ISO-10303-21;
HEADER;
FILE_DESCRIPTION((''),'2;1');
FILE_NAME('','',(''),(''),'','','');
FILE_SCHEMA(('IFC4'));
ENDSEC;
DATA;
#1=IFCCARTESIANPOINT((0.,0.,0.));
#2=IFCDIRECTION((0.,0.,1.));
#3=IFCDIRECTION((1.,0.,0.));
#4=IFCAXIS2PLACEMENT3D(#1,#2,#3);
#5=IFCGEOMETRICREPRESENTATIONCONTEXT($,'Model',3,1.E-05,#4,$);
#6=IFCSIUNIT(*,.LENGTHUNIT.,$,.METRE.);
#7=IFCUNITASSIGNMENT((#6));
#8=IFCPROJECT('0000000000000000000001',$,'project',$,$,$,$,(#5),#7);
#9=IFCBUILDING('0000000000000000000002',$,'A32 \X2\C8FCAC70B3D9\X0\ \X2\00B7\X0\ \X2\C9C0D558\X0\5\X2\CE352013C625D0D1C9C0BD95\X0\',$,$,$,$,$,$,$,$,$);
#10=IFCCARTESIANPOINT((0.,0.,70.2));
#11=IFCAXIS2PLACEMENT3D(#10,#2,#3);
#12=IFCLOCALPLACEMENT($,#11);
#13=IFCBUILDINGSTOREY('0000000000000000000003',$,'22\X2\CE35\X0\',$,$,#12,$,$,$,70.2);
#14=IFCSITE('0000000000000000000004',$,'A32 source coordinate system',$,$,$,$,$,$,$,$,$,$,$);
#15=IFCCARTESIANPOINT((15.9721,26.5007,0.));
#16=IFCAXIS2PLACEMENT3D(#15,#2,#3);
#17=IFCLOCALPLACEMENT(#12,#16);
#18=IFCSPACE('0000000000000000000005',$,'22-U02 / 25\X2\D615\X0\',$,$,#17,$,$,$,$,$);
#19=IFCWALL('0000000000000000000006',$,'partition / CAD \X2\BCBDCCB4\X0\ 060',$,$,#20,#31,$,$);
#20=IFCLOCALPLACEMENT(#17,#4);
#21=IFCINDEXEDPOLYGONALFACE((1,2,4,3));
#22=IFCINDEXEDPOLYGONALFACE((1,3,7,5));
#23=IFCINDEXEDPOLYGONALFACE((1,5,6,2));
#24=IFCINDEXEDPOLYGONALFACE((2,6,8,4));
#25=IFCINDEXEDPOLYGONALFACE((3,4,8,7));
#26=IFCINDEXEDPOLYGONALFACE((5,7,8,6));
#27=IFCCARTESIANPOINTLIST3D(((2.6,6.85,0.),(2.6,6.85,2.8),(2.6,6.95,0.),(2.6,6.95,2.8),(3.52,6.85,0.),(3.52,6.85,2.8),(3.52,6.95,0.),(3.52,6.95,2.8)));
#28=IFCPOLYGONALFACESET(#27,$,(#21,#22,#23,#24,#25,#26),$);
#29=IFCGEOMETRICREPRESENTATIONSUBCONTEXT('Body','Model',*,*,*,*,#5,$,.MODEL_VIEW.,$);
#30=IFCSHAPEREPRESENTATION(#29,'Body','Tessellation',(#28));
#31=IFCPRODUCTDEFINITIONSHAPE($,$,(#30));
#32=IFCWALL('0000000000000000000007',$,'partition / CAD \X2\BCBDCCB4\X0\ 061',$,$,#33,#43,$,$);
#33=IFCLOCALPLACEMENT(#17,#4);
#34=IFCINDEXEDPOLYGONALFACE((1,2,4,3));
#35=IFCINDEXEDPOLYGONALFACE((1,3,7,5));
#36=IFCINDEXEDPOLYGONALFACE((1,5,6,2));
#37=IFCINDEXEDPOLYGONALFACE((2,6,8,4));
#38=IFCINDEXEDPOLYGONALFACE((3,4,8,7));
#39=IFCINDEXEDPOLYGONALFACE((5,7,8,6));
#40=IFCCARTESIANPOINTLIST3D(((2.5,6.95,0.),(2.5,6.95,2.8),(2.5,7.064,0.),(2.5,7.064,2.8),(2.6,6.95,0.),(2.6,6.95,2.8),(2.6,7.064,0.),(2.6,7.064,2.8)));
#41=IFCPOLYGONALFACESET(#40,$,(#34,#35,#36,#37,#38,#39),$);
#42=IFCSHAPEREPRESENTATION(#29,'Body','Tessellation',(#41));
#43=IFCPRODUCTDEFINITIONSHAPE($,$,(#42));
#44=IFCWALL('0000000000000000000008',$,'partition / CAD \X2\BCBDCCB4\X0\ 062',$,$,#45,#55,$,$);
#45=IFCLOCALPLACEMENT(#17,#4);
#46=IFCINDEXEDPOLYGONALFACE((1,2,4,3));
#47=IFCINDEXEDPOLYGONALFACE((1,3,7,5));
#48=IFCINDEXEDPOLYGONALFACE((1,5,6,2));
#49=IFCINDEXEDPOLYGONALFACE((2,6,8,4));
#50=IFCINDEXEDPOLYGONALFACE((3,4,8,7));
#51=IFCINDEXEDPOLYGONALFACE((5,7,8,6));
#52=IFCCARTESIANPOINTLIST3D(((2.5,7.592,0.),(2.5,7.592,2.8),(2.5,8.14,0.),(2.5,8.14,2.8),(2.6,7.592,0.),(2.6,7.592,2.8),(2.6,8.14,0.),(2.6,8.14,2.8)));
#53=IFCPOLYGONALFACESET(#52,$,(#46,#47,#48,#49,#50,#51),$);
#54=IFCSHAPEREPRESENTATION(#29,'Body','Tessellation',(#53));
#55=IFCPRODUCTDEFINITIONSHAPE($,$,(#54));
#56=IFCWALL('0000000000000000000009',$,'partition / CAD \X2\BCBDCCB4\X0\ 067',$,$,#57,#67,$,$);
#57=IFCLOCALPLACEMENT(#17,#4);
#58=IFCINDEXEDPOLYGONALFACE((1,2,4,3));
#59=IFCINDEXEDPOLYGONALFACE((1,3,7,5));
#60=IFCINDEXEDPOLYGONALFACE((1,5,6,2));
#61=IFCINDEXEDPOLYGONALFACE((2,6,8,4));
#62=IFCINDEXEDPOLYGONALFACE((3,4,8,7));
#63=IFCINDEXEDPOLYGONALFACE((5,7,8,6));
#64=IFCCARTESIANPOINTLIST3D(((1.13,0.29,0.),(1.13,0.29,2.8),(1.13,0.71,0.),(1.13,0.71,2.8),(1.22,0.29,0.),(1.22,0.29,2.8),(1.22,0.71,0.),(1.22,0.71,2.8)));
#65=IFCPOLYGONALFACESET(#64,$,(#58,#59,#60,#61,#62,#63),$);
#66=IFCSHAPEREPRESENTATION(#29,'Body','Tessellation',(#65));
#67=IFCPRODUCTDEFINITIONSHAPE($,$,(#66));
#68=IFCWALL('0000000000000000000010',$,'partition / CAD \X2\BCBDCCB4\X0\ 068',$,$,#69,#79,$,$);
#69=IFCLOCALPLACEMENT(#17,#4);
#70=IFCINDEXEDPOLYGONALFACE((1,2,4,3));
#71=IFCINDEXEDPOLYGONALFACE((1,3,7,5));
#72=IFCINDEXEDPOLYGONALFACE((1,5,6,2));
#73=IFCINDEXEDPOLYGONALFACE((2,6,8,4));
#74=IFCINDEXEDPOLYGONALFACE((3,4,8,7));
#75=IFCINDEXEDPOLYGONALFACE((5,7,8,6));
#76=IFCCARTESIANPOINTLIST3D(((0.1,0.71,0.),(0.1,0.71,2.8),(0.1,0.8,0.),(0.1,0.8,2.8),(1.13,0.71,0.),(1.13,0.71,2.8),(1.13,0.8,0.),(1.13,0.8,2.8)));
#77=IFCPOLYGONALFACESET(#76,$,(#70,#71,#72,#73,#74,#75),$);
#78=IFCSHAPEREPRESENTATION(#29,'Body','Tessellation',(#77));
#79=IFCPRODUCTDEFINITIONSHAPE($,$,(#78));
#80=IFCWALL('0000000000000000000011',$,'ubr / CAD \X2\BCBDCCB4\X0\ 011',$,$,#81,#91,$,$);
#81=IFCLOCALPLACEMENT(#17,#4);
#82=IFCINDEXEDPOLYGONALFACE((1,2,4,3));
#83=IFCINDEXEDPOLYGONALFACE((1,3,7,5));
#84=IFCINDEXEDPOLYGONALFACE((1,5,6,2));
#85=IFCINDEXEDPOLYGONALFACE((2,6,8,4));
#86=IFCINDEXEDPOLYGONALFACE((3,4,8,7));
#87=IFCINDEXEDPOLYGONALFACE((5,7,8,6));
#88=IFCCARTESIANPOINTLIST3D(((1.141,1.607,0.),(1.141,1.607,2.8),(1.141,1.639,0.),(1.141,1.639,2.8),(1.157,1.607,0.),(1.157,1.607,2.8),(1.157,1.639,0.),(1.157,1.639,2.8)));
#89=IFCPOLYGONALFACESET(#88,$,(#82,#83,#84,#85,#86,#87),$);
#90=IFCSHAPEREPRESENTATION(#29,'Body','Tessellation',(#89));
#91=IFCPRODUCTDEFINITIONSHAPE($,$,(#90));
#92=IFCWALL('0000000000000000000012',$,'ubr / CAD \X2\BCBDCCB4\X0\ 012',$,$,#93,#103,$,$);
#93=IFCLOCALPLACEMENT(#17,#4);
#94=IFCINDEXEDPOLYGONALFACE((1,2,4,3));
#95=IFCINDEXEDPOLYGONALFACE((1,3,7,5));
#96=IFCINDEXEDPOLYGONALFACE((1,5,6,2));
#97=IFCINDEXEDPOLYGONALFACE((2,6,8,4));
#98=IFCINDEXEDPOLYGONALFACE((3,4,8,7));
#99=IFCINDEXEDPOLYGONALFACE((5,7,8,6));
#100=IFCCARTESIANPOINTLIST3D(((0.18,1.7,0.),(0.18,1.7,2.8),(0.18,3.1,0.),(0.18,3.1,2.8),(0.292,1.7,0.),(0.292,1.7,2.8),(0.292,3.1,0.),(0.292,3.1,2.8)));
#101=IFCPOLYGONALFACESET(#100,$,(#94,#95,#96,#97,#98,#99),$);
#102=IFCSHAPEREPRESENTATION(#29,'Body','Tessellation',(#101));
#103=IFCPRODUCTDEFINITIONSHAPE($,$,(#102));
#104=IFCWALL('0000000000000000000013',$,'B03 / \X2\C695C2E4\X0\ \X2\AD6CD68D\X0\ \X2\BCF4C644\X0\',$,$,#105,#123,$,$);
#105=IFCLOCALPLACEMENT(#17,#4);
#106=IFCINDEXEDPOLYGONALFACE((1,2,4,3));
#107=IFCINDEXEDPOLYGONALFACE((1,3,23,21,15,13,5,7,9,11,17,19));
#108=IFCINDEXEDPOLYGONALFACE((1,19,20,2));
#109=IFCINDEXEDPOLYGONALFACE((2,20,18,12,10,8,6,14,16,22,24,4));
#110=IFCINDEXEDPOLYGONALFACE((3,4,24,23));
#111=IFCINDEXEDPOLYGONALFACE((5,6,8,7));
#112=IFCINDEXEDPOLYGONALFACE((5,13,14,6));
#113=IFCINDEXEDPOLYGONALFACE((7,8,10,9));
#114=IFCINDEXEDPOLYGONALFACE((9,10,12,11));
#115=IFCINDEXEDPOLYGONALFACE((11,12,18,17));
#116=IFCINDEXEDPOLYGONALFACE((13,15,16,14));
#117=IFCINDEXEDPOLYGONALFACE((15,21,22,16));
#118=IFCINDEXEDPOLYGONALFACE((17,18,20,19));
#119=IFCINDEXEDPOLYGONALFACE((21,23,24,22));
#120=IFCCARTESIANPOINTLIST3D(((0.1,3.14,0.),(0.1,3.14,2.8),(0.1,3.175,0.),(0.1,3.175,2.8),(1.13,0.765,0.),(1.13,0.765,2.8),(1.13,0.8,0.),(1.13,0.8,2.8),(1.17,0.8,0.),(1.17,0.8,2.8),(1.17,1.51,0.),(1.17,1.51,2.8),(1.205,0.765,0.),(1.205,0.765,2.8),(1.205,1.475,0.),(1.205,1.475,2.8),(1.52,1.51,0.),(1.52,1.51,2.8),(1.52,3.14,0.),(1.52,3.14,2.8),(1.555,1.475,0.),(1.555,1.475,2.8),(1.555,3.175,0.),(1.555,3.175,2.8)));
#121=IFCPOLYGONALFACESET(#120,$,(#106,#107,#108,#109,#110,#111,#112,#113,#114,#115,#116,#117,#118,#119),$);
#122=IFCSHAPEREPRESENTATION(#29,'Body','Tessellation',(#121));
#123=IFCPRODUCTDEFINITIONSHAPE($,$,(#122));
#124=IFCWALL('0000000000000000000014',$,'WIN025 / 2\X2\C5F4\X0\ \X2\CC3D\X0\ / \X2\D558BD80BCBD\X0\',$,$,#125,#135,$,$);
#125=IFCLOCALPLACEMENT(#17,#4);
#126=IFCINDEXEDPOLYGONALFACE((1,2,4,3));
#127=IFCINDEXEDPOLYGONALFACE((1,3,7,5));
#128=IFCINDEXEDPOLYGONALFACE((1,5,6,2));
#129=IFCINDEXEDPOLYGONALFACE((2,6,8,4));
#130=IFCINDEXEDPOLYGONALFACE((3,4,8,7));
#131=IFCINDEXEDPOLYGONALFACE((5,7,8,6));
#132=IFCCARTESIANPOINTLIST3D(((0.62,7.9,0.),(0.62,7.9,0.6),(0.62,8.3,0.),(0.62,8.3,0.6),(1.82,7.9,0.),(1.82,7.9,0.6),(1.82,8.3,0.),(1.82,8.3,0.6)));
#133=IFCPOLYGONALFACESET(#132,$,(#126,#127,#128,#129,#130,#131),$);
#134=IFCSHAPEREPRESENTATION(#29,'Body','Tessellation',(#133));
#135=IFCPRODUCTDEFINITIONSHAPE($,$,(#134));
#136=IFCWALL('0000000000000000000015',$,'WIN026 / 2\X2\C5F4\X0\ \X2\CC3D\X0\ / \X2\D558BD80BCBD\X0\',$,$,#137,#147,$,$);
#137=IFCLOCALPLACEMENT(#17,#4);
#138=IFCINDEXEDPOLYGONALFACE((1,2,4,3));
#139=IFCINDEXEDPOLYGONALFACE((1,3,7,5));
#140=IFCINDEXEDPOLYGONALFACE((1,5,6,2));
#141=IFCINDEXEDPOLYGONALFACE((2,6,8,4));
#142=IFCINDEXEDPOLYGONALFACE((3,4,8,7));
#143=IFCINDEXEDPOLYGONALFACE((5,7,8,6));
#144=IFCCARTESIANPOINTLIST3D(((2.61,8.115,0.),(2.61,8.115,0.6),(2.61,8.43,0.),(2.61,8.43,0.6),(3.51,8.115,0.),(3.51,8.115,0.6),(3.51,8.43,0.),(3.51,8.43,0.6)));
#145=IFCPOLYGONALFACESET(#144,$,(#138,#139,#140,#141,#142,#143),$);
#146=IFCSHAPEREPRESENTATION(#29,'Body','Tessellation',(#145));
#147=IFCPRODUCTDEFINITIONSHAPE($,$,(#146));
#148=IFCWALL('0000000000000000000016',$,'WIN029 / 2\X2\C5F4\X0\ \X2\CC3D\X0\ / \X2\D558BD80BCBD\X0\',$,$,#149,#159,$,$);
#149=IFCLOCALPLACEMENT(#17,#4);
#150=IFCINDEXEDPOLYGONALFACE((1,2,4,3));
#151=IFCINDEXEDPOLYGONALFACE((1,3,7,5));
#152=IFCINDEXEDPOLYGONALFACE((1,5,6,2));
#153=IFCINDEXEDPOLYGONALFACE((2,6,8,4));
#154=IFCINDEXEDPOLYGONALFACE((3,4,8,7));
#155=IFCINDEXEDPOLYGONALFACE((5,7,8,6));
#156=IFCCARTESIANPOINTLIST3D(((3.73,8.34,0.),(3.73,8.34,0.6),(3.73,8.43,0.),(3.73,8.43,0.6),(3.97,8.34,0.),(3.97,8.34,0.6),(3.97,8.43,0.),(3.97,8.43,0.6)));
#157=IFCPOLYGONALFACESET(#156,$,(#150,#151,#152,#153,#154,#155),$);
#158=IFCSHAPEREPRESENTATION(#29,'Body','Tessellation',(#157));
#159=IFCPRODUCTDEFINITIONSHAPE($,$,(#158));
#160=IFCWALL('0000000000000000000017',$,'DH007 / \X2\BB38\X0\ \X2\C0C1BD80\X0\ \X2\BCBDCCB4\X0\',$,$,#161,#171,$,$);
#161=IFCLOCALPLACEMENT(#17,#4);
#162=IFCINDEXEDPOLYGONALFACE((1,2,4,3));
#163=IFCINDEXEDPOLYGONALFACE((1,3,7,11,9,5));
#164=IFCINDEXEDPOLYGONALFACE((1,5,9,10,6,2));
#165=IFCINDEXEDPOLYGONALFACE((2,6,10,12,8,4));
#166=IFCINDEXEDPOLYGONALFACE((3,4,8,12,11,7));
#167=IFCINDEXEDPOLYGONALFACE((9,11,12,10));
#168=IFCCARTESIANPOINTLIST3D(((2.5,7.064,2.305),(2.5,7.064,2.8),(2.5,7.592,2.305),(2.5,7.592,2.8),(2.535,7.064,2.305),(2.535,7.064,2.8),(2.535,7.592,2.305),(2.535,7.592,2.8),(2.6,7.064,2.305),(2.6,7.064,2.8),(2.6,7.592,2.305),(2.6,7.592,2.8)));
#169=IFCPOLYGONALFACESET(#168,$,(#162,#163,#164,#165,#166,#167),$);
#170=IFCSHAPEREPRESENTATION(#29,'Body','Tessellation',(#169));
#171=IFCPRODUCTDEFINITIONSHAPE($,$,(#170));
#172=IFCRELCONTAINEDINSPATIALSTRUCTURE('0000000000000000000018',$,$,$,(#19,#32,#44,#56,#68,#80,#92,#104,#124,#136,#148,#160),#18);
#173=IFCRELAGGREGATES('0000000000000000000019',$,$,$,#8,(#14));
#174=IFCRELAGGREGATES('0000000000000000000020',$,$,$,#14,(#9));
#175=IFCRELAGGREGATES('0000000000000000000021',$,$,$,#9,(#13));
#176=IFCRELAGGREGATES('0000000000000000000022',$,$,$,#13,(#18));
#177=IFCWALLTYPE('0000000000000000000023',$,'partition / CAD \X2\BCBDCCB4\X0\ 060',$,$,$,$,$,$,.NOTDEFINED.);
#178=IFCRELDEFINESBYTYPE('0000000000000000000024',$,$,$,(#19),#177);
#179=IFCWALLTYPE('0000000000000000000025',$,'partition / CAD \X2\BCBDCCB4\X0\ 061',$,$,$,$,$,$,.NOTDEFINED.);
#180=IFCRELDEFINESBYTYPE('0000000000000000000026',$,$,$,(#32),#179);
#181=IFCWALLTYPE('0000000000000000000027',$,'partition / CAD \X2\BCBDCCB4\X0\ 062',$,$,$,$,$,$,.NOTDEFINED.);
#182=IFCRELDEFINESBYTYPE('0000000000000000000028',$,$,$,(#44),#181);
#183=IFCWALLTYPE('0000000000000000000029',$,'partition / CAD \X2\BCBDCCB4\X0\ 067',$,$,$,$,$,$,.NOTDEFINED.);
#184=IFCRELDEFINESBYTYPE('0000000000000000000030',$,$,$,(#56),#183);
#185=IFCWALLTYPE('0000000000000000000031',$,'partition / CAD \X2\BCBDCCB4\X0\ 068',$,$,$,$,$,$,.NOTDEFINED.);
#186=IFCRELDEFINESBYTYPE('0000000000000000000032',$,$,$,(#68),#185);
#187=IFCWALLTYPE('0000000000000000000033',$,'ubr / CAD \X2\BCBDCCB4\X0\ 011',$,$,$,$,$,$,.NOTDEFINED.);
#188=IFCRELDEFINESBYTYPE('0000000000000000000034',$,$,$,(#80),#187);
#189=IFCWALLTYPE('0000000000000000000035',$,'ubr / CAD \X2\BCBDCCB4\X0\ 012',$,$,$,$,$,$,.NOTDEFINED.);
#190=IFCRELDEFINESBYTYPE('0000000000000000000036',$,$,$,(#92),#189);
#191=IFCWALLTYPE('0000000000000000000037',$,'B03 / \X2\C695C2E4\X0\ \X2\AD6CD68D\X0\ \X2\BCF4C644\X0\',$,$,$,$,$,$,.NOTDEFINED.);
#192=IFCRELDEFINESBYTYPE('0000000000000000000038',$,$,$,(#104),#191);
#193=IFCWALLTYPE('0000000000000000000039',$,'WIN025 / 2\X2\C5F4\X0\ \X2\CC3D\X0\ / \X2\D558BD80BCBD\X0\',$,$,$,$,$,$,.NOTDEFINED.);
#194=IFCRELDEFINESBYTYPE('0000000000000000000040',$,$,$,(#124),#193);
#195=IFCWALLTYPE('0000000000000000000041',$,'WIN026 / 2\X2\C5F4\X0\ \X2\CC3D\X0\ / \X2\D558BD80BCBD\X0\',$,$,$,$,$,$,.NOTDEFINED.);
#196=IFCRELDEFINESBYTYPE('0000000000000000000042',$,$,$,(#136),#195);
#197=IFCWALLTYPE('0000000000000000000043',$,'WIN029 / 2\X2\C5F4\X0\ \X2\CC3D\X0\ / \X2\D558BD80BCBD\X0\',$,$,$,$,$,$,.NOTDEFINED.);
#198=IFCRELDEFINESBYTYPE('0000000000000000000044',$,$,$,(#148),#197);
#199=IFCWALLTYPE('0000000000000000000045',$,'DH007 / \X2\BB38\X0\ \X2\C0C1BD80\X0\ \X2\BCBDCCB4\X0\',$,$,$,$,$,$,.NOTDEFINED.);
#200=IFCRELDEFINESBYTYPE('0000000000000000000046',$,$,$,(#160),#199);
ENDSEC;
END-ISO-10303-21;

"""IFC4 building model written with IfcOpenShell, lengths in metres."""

from ifc_helpers import new_model, si_unit, frame, origin, origin_with_axes, place, context, subcontext, project, spatial, polyline, outline, extrude, source, transform, mapped, type_object, type_shapes, element, save


model = new_model("IFC4")

# Units and contexts
model_context = context("Model", 3, precision=1e-05, world=origin_with_axes())
body_context = subcontext(model_context, "Body", "Model", "MODEL_VIEW")
ifc_project = project(units=[si_unit("LENGTHUNIT", "METRE")], contexts=[model_context])

# Site, building, storey, space
site = spatial("IfcSite", under=ifc_project, Name="A32 source coordinate system")
building = spatial("IfcBuilding", under=site, Name="A32 주거동 · 지하5층–옥탑지붕")
storey_placement = place(None, frame((0.0, 0.0, 70.2), z_axis=(0.0, 0.0, 1.0), x_axis=(1.0, 0.0, 0.0)))
storey = spatial("IfcBuildingStorey", under=building, at=storey_placement, Name="22층", Elevation=70.2)
space_1_placement = place(storey_placement, frame((15.9721, 26.5007, 0.0), z_axis=(0.0, 0.0, 1.0), x_axis=(1.0, 0.0, 0.0)))
space_1 = spatial("IfcSpace", under=storey, at=space_1_placement, Name="22-U02 / 25형")

# Walls
wall_type_1 = type_object("IfcWallType", Name="partition / CAD 벽체 060", PredefinedType="NOTDEFINED")
shared_shape_1 = source(origin(), body_context, "Body", "SweptSolid", [
    extrude(outline(polyline([(3.52, 6.85), (2.6, 6.85), (2.6, 6.95), (3.52, 6.95), (3.52, 6.85)])), origin(), (0.0, 0.0, 1.0), 2.8),
])
type_shapes(wall_type_1, [shared_shape_1])
wall_1_placement = place(space_1_placement, origin_with_axes())
element("IfcWall", 1, at=wall_1_placement, inside=space_1, type_object=wall_type_1, Name="partition / CAD 벽체 060", context=body_context, shape_type="MappedRepresentation", body=[
    mapped(shared_shape_1, transform((0.0, 0.0, 0.0), scale=1.0)),
])
wall_type_2 = type_object("IfcWallType", Name="partition / CAD 벽체 061", PredefinedType="NOTDEFINED")
shared_shape_2 = source(origin(), body_context, "Body", "SweptSolid", [
    extrude(outline(polyline([(2.6, 7.064), (2.6, 6.95), (2.5, 6.95), (2.5, 7.064), (2.6, 7.064)])), origin(), (0.0, 0.0, 1.0), 2.8),
])
type_shapes(wall_type_2, [shared_shape_2])
wall_2_placement = place(space_1_placement, origin_with_axes())
element("IfcWall", 2, at=wall_2_placement, inside=space_1, type_object=wall_type_2, Name="partition / CAD 벽체 061", context=body_context, shape_type="MappedRepresentation", body=[
    mapped(shared_shape_2, transform((0.0, 0.0, 0.0), scale=1.0)),
])
wall_type_3 = type_object("IfcWallType", Name="partition / CAD 벽체 062", PredefinedType="NOTDEFINED")
shared_shape_3 = source(origin(), body_context, "Body", "SweptSolid", [
    extrude(outline(polyline([(2.5, 7.592), (2.5, 8.14), (2.6, 8.14), (2.6, 7.592), (2.5, 7.592)])), origin(), (0.0, 0.0, 1.0), 2.8),
])
type_shapes(wall_type_3, [shared_shape_3])
wall_3_placement = place(space_1_placement, origin_with_axes())
element("IfcWall", 3, at=wall_3_placement, inside=space_1, type_object=wall_type_3, Name="partition / CAD 벽체 062", context=body_context, shape_type="MappedRepresentation", body=[
    mapped(shared_shape_3, transform((0.0, 0.0, 0.0), scale=1.0)),
])
wall_type_4 = type_object("IfcWallType", Name="partition / CAD 벽체 067", PredefinedType="NOTDEFINED")
shared_shape_4 = source(origin(), body_context, "Body", "SweptSolid", [
    extrude(outline(polyline([(1.22, 0.71), (1.22, 0.29), (1.13, 0.29), (1.13, 0.71), (1.22, 0.71)])), origin(), (0.0, 0.0, 1.0), 2.8),
])
type_shapes(wall_type_4, [shared_shape_4])
wall_4_placement = place(space_1_placement, origin_with_axes())
element("IfcWall", 4, at=wall_4_placement, inside=space_1, type_object=wall_type_4, Name="partition / CAD 벽체 067", context=body_context, shape_type="MappedRepresentation", body=[
    mapped(shared_shape_4, transform((0.0, 0.0, 0.0), scale=1.0)),
])
wall_type_5 = type_object("IfcWallType", Name="partition / CAD 벽체 068", PredefinedType="NOTDEFINED")
shared_shape_5 = source(origin(), body_context, "Body", "SweptSolid", [
    extrude(outline(polyline([(1.13, 0.8), (1.13, 0.71), (0.1, 0.71), (0.1, 0.8), (1.13, 0.8)])), origin(), (0.0, 0.0, 1.0), 2.8),
])
type_shapes(wall_type_5, [shared_shape_5])
wall_5_placement = place(space_1_placement, origin_with_axes())
element("IfcWall", 5, at=wall_5_placement, inside=space_1, type_object=wall_type_5, Name="partition / CAD 벽체 068", context=body_context, shape_type="MappedRepresentation", body=[
    mapped(shared_shape_5, transform((0.0, 0.0, 0.0), scale=1.0)),
])
wall_type_6 = type_object("IfcWallType", Name="ubr / CAD 벽체 011", PredefinedType="NOTDEFINED")
shared_shape_6 = source(origin(), body_context, "Body", "SweptSolid", [
    extrude(outline(polyline([(1.141, 1.607), (1.141, 1.639), (1.157, 1.639), (1.157, 1.607), (1.141, 1.607)])), origin(), (0.0, 0.0, 1.0), 2.8),
])
type_shapes(wall_type_6, [shared_shape_6])
wall_6_placement = place(space_1_placement, origin_with_axes())
element("IfcWall", 6, at=wall_6_placement, inside=space_1, type_object=wall_type_6, Name="ubr / CAD 벽체 011", context=body_context, shape_type="MappedRepresentation", body=[
    mapped(shared_shape_6, transform((0.0, 0.0, 0.0), scale=1.0)),
])
wall_type_7 = type_object("IfcWallType", Name="ubr / CAD 벽체 012", PredefinedType="NOTDEFINED")
shared_shape_7 = source(origin(), body_context, "Body", "SweptSolid", [
    extrude(outline(polyline([(0.18, 1.7), (0.18, 3.1), (0.292, 3.1), (0.292, 1.7), (0.18, 1.7)])), origin(), (0.0, 0.0, 1.0), 2.8),
])
type_shapes(wall_type_7, [shared_shape_7])
wall_7_placement = place(space_1_placement, origin_with_axes())
element("IfcWall", 7, at=wall_7_placement, inside=space_1, type_object=wall_type_7, Name="ubr / CAD 벽체 012", context=body_context, shape_type="MappedRepresentation", body=[
    mapped(shared_shape_7, transform((0.0, 0.0, 0.0), scale=1.0)),
])
wall_type_8 = type_object("IfcWallType", Name="B03 / 욕실 구획 보완", PredefinedType="NOTDEFINED")
shared_shape_8 = source(origin(), body_context, "Body", "SweptSolid", [
    extrude(outline(polyline([(1.13, 0.765), (1.13, 0.8), (1.17, 0.8), (1.17, 1.51), (1.52, 1.51), (1.52, 3.14), (0.1, 3.14), (0.1, 3.175), (1.555, 3.175), (1.555, 1.475), (1.205, 1.475), (1.205, 0.765), (1.13, 0.765)])), origin(), (0.0, 0.0, 1.0), 2.8),
])
type_shapes(wall_type_8, [shared_shape_8])
wall_8_placement = place(space_1_placement, origin_with_axes())
element("IfcWall", 8, at=wall_8_placement, inside=space_1, type_object=wall_type_8, Name="B03 / 욕실 구획 보완", context=body_context, shape_type="MappedRepresentation", body=[
    mapped(shared_shape_8, transform((0.0, 0.0, 0.0), scale=1.0)),
])
wall_type_9 = type_object("IfcWallType", Name="WIN025 / 2열 창 / 하부벽", PredefinedType="NOTDEFINED")
shared_shape_9 = source(origin(), body_context, "Body", "SweptSolid", [
    extrude(outline(polyline([(1.82, 8.3), (1.82, 7.9), (0.62, 7.9), (0.62, 8.3), (1.82, 8.3)])), origin(), (0.0, 0.0, 1.0), 0.6),
])
type_shapes(wall_type_9, [shared_shape_9])
wall_9_placement = place(space_1_placement, origin_with_axes())
element("IfcWall", 9, at=wall_9_placement, inside=space_1, type_object=wall_type_9, Name="WIN025 / 2열 창 / 하부벽", context=body_context, shape_type="MappedRepresentation", body=[
    mapped(shared_shape_9, transform((0.0, 0.0, 0.0), scale=1.0)),
])
wall_type_10 = type_object("IfcWallType", Name="WIN026 / 2열 창 / 하부벽", PredefinedType="NOTDEFINED")
shared_shape_10 = source(origin(), body_context, "Body", "SweptSolid", [
    extrude(outline(polyline([(3.51, 8.43), (3.51, 8.115), (2.61, 8.115), (2.61, 8.43), (3.51, 8.43)])), origin(), (0.0, 0.0, 1.0), 0.6),
])
type_shapes(wall_type_10, [shared_shape_10])
wall_10_placement = place(space_1_placement, origin_with_axes())
element("IfcWall", 10, at=wall_10_placement, inside=space_1, type_object=wall_type_10, Name="WIN026 / 2열 창 / 하부벽", context=body_context, shape_type="MappedRepresentation", body=[
    mapped(shared_shape_10, transform((0.0, 0.0, 0.0), scale=1.0)),
])
wall_type_11 = type_object("IfcWallType", Name="WIN029 / 2열 창 / 하부벽", PredefinedType="NOTDEFINED")
shared_shape_11 = source(origin(), body_context, "Body", "SweptSolid", [
    extrude(outline(polyline([(3.97, 8.43), (3.97, 8.34), (3.73, 8.34), (3.73, 8.43), (3.97, 8.43)])), origin(), (0.0, 0.0, 1.0), 0.6),
])
type_shapes(wall_type_11, [shared_shape_11])
wall_11_placement = place(space_1_placement, origin_with_axes())
element("IfcWall", 11, at=wall_11_placement, inside=space_1, type_object=wall_type_11, Name="WIN029 / 2열 창 / 하부벽", context=body_context, shape_type="MappedRepresentation", body=[
    mapped(shared_shape_11, transform((0.0, 0.0, 0.0), scale=1.0)),
])
wall_type_12 = type_object("IfcWallType", Name="DH007 / 문 상부 벽체", PredefinedType="NOTDEFINED")
shared_shape_12 = source(origin(), body_context, "Body", "SweptSolid", [
    extrude(outline(polyline([(2.5, 7.592), (2.535, 7.592), (2.6, 7.592), (2.6, 7.064), (2.535, 7.064), (2.5, 7.064), (2.5, 7.592)])), frame((0.0, 0.0, 2.305)), (0.0, 0.0, 1.0), 0.495),
])
type_shapes(wall_type_12, [shared_shape_12])
wall_12_placement = place(space_1_placement, origin_with_axes())
element("IfcWall", 12, at=wall_12_placement, inside=space_1, type_object=wall_type_12, Name="DH007 / 문 상부 벽체", context=body_context, shape_type="MappedRepresentation", body=[
    mapped(shared_shape_12, transform((0.0, 0.0, 0.0), scale=1.0)),
])

save(model, "model.ifc")
